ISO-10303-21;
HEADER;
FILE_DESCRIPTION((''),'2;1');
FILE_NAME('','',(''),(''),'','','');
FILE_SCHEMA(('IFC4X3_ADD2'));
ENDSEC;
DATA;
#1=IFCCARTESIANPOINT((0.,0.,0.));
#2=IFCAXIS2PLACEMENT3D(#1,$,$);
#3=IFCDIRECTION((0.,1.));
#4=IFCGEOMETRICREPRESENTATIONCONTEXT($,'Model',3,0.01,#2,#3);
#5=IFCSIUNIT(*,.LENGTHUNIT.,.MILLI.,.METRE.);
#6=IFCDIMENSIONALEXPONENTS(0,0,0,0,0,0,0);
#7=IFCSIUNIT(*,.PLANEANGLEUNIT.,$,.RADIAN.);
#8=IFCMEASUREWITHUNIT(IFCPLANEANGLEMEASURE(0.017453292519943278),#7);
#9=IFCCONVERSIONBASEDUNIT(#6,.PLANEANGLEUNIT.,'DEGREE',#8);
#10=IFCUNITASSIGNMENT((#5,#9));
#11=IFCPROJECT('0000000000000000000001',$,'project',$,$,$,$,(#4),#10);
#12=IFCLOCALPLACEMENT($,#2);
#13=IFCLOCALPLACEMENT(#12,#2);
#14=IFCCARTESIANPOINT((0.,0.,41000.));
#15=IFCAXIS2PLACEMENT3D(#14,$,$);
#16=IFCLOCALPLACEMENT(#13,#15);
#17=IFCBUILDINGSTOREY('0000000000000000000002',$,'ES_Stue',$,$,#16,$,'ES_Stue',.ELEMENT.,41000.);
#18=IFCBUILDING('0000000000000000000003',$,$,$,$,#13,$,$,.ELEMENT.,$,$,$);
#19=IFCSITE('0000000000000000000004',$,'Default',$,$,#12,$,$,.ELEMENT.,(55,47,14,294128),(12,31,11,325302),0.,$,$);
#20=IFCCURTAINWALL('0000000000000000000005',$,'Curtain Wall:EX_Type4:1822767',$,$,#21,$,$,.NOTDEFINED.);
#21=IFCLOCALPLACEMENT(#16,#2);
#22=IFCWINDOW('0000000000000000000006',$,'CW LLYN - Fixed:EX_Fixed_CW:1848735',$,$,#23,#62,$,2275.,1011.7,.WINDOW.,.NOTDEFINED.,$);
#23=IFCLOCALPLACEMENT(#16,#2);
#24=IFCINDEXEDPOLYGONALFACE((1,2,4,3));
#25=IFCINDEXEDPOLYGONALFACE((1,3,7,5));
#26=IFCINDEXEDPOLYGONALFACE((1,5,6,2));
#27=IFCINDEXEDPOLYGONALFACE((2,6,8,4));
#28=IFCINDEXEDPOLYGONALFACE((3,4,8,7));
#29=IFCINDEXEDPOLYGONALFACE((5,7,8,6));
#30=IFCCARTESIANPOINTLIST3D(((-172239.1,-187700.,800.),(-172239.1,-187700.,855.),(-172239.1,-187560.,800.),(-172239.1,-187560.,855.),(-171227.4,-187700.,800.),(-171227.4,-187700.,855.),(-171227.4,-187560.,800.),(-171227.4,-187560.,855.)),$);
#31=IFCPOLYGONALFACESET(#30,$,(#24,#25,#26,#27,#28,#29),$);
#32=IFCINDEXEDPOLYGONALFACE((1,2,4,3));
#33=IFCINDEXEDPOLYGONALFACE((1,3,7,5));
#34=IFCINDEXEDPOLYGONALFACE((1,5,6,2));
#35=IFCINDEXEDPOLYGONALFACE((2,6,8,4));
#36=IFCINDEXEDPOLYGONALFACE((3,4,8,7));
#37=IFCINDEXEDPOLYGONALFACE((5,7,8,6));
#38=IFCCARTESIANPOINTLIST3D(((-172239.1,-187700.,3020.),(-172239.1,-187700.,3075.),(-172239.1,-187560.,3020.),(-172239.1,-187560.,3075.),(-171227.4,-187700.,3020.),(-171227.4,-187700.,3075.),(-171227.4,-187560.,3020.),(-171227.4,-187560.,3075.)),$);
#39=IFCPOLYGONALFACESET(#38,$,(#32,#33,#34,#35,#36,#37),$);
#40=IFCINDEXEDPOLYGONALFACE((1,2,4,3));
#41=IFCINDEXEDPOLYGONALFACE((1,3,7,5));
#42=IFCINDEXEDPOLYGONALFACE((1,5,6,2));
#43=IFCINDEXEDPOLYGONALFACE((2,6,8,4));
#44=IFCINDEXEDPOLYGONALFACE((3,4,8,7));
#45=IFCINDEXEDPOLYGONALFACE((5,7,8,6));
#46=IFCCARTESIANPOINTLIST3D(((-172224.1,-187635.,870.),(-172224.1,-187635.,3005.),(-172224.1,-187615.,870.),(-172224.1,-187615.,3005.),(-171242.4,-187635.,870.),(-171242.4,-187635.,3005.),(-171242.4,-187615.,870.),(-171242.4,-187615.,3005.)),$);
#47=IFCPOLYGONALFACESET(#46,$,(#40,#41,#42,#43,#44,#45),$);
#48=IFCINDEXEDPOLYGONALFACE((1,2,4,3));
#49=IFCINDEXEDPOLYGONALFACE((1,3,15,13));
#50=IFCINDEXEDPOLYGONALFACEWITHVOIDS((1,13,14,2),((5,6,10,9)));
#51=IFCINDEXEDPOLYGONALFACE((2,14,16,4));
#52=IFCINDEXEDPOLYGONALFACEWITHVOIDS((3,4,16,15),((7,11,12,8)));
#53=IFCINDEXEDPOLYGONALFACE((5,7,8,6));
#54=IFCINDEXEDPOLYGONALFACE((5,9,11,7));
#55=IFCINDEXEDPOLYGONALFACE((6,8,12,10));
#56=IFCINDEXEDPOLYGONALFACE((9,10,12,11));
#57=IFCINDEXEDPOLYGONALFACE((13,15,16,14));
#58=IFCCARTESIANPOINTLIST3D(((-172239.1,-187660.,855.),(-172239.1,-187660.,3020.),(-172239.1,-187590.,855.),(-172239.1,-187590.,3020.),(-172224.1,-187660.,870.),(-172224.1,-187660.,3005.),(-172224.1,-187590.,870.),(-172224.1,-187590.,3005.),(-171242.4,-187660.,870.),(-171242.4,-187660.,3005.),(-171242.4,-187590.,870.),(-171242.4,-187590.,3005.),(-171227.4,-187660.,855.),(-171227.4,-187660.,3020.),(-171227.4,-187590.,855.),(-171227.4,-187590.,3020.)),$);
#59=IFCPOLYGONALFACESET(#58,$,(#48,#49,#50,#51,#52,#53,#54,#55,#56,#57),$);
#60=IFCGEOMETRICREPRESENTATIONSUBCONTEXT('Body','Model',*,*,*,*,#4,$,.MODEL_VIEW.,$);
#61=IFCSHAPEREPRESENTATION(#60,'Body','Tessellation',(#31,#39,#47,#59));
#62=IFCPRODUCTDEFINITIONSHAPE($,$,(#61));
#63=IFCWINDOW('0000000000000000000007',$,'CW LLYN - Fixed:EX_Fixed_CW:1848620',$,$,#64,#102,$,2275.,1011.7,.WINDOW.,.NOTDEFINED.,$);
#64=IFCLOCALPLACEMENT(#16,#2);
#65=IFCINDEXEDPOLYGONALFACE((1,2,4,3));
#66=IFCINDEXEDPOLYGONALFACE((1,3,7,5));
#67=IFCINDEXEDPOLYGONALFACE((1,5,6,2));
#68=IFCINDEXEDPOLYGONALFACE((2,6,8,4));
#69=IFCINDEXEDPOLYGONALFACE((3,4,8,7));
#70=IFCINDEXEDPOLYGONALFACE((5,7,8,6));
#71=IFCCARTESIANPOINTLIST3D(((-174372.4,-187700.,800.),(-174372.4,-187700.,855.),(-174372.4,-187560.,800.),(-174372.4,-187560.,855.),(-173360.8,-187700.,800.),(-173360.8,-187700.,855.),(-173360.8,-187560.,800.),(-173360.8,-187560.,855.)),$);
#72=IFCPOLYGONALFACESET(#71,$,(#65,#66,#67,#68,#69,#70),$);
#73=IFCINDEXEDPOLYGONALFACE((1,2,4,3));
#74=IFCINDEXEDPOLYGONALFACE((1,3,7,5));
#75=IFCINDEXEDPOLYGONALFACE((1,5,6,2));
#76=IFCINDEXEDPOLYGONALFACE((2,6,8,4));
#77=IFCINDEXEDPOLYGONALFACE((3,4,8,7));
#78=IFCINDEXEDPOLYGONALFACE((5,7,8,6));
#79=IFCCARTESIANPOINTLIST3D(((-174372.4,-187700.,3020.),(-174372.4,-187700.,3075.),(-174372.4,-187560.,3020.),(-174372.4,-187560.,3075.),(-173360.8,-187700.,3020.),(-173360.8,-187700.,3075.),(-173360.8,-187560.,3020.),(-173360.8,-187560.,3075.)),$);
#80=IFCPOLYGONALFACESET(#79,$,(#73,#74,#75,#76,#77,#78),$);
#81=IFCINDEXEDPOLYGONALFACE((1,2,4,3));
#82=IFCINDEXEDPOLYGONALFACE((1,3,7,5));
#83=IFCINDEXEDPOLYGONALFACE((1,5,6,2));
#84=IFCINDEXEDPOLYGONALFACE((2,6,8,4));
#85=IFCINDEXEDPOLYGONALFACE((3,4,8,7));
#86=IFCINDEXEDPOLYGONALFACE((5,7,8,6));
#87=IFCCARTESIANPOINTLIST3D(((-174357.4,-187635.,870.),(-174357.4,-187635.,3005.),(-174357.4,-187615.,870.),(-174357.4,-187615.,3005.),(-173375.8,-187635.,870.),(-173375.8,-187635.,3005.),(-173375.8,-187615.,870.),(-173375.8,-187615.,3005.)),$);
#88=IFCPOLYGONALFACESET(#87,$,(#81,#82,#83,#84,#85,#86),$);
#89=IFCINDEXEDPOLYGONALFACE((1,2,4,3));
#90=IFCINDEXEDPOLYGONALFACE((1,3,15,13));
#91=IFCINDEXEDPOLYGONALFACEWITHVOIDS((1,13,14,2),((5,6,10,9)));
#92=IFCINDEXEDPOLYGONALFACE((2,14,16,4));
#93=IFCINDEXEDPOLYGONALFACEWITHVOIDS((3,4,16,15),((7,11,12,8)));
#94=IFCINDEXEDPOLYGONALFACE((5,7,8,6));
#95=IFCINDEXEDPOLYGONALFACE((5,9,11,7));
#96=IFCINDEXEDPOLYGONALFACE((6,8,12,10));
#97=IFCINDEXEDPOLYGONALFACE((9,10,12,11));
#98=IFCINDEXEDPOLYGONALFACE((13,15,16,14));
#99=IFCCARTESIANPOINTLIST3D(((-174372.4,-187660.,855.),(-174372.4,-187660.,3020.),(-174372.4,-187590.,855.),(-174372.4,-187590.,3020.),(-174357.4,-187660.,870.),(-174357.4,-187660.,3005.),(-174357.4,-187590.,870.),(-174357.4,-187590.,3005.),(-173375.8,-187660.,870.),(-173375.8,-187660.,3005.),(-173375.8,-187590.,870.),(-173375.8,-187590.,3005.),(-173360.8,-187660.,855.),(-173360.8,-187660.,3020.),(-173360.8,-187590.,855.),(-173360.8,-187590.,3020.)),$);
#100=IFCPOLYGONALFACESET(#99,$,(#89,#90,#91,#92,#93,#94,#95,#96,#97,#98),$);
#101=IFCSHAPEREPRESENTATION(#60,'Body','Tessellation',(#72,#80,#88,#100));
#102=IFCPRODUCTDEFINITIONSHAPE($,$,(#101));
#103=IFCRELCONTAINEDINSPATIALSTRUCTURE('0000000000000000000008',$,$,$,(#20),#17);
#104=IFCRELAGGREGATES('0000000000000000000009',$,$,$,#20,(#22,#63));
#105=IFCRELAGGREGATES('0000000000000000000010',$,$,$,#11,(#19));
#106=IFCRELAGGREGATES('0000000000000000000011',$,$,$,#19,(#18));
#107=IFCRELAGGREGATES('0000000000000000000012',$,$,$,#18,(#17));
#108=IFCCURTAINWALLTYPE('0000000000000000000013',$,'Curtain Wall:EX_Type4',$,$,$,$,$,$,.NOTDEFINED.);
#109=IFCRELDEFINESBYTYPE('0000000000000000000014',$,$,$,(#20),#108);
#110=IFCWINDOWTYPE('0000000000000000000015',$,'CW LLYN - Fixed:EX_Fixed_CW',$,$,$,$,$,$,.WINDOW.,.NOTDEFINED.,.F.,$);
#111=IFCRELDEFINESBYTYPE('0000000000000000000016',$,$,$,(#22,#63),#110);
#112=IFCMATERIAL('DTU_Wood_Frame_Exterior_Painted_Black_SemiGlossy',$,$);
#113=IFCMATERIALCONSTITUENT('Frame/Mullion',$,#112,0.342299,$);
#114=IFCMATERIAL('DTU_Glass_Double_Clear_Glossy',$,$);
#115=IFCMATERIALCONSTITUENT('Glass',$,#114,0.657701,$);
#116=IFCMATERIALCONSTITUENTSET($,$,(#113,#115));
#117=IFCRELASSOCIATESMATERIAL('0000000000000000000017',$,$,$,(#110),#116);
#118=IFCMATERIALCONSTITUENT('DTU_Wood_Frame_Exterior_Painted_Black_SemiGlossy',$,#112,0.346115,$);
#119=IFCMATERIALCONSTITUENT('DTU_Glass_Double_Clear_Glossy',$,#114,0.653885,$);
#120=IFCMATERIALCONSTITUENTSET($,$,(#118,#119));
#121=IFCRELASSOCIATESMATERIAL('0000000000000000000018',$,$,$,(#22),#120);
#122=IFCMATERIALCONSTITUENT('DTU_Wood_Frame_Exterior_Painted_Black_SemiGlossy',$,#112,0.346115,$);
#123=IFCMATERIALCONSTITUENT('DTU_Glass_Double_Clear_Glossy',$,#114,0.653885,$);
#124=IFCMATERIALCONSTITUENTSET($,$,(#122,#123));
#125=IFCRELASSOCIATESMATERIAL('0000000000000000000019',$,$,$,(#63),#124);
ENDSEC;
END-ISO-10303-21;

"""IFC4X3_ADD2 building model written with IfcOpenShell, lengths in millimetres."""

from ifc_helpers import new_model, entity, si_unit, converted_unit, direction, frame, frame_2d, origin, origin_2d_with_axis, place, context, subcontext, project, spatial, polyline, rectangle, outline, extrude, source, transform, mapped, material, constituent, constituent_set, type_object, type_shapes, element, aggregate, save


model = new_model("IFC4X3_ADD2")

# Units and contexts
model_context = context("Model", 3, precision=0.01, world=origin(), true_north=direction((0.0, 1.0)))
body_context = subcontext(model_context, "Body", "Model", "MODEL_VIEW")
ifc_project = project(units=[si_unit("LENGTHUNIT", "METRE", prefix="MILLI"), converted_unit("PLANEANGLEUNIT", "DEGREE", entity("IfcPlaneAngleMeasure", 0.017453292519943278), si_unit("PLANEANGLEUNIT", "RADIAN"), dimensions=[0, 0, 0, 0, 0, 0, 0])], contexts=[model_context])

# Site, building, storey
site_placement = place(None, origin())
site = spatial("IfcSite", under=ifc_project, at=site_placement, Name="Default", CompositionType="ELEMENT", RefLatitude=(55, 47, 14, 294128), RefLongitude=(12, 31, 11, 325302), RefElevation=0.0)
building_placement = place(site_placement, origin())
building = spatial("IfcBuilding", under=site, at=building_placement, CompositionType="ELEMENT")
storey_placement = place(building_placement, frame((0.0, 0.0, 41000.0)))
storey = spatial("IfcBuildingStorey", under=building, at=storey_placement, Name="ES_Stue", LongName="ES_Stue", CompositionType="ELEMENT", Elevation=41000.0)

# Curtain wall, windows
curtain_wall_type = type_object("IfcCurtainWallType", Name="Curtain Wall:EX_Type4", PredefinedType="NOTDEFINED")
curtain_wall_placement = place(storey_placement, frame((0.0, 0.0, -41000.0)))
curtain_wall = element("IfcCurtainWall", 1, at=curtain_wall_placement, inside=storey, type_object=curtain_wall_type, Name="Curtain Wall:EX_Type4:1822767", PredefinedType="NOTDEFINED")
ifc_material_1 = material(Name="DTU_Wood_Frame_Exterior_Painted_Black_SemiGlossy")
ifc_material_2 = material(Name="DTU_Glass_Double_Clear_Glossy")
ifc_constituent_1 = constituent(ifc_material_1, Name="Frame/Mullion", fraction=0.342299)
ifc_constituent_2 = constituent(ifc_material_2, Name="Glass", fraction=0.657701)
ifc_constituent_set_1 = constituent_set(constituents=[ifc_constituent_1, ifc_constituent_2])
window_type_1 = type_object("IfcWindowType", Name="CW LLYN - Fixed:EX_Fixed_CW", ParameterTakesPrecedence=False, PartitioningType="NOTDEFINED", PredefinedType="WINDOW", material=ifc_constituent_set_1)
shared_shape_1 = source(origin(), body_context, "Body", "SweptSolid", [
    extrude(rectangle(XDim=140.0, YDim=1011.7, at=origin_2d_with_axis()), frame((0.0, -130.0, 0.0), z_axis=(0.0, 0.0, 1.0), x_axis=(0.0, -1.0, 0.0)), (0.0, 0.0, 1.0), 55.0),
    extrude(rectangle(XDim=140.0, YDim=1011.7, at=frame_2d((0.0, 0.0), x_axis=(1.0, 0.0))), frame((0.0, -130.0, 2220.0), z_axis=(0.0, 0.0, 1.0), x_axis=(0.0, -1.0, 0.0)), (0.0, 0.0, 1.0), 55.0),
    extrude(rectangle(XDim=981.7, YDim=20.0, at=frame_2d((0.0, 0.0), x_axis=(1.0, 0.0))), frame((0.0, -125.0, 70.0), z_axis=(0.0, 0.0, 1.0), x_axis=(-1.0, 0.0, 0.0)), (0.0, 0.0, 1.0), 2135.0),
    extrude(outline(polyline([(-1082.5, -505.8), (1082.5, -505.8), (1082.5, 505.8), (-1082.5, 505.8), (-1082.5, -505.8)]), holes=[polyline([(-1067.5, 490.8), (1067.5, 490.8), (1067.5, -490.8), (-1067.5, -490.8), (-1067.5, 490.8)])]), frame((0.0, -90.0, 1137.5), z_axis=(0.0, -1.0, 0.0), x_axis=(0.0, 0.0, 1.0)), (0.0, 0.0, 1.0), 70.0),
])
type_shapes(window_type_1, [shared_shape_1])
ifc_constituent_3 = constituent(ifc_material_1, Name="DTU_Wood_Frame_Exterior_Painted_Black_SemiGlossy", fraction=0.346115)
ifc_constituent_4 = constituent(ifc_material_2, Name="DTU_Glass_Double_Clear_Glossy", fraction=0.653885)
ifc_constituent_set_2 = constituent_set(constituents=[ifc_constituent_3, ifc_constituent_4])
window_1_placement = place(curtain_wall_placement, frame((-171733.3, -187500.0, 41800.0)))
window_1 = element("IfcWindow", 2, at=window_1_placement, type_object=window_type_1, material=ifc_constituent_set_2, Name="CW LLYN - Fixed:EX_Fixed_CW:1848735", OverallHeight=2275.0, OverallWidth=1011.7, PartitioningType="NOTDEFINED", PredefinedType="WINDOW", context=body_context, shape_type="MappedRepresentation", body=[
    mapped(shared_shape_1, transform((0.0, 0.0, 0.0), scale=1.0)),
])
ifc_constituent_5 = constituent(ifc_material_1, Name="DTU_Wood_Frame_Exterior_Painted_Black_SemiGlossy", fraction=0.346115)
ifc_constituent_6 = constituent(ifc_material_2, Name="DTU_Glass_Double_Clear_Glossy", fraction=0.653885)
ifc_constituent_set_3 = constituent_set(constituents=[ifc_constituent_5, ifc_constituent_6])
window_2_placement = place(curtain_wall_placement, frame((-173866.6, -187500.0, 41800.0)))
window_2 = element("IfcWindow", 3, at=window_2_placement, type_object=window_type_1, material=ifc_constituent_set_3, Name="CW LLYN - Fixed:EX_Fixed_CW:1848620", OverallHeight=2275.0, OverallWidth=1011.7, PartitioningType="NOTDEFINED", PredefinedType="WINDOW", context=body_context, shape_type="MappedRepresentation", body=[
    mapped(shared_shape_1, transform((0.0, 0.0, 0.0), scale=1.0)),
])
aggregate(curtain_wall, [window_1, window_2])

save(model, "model.ifc")
